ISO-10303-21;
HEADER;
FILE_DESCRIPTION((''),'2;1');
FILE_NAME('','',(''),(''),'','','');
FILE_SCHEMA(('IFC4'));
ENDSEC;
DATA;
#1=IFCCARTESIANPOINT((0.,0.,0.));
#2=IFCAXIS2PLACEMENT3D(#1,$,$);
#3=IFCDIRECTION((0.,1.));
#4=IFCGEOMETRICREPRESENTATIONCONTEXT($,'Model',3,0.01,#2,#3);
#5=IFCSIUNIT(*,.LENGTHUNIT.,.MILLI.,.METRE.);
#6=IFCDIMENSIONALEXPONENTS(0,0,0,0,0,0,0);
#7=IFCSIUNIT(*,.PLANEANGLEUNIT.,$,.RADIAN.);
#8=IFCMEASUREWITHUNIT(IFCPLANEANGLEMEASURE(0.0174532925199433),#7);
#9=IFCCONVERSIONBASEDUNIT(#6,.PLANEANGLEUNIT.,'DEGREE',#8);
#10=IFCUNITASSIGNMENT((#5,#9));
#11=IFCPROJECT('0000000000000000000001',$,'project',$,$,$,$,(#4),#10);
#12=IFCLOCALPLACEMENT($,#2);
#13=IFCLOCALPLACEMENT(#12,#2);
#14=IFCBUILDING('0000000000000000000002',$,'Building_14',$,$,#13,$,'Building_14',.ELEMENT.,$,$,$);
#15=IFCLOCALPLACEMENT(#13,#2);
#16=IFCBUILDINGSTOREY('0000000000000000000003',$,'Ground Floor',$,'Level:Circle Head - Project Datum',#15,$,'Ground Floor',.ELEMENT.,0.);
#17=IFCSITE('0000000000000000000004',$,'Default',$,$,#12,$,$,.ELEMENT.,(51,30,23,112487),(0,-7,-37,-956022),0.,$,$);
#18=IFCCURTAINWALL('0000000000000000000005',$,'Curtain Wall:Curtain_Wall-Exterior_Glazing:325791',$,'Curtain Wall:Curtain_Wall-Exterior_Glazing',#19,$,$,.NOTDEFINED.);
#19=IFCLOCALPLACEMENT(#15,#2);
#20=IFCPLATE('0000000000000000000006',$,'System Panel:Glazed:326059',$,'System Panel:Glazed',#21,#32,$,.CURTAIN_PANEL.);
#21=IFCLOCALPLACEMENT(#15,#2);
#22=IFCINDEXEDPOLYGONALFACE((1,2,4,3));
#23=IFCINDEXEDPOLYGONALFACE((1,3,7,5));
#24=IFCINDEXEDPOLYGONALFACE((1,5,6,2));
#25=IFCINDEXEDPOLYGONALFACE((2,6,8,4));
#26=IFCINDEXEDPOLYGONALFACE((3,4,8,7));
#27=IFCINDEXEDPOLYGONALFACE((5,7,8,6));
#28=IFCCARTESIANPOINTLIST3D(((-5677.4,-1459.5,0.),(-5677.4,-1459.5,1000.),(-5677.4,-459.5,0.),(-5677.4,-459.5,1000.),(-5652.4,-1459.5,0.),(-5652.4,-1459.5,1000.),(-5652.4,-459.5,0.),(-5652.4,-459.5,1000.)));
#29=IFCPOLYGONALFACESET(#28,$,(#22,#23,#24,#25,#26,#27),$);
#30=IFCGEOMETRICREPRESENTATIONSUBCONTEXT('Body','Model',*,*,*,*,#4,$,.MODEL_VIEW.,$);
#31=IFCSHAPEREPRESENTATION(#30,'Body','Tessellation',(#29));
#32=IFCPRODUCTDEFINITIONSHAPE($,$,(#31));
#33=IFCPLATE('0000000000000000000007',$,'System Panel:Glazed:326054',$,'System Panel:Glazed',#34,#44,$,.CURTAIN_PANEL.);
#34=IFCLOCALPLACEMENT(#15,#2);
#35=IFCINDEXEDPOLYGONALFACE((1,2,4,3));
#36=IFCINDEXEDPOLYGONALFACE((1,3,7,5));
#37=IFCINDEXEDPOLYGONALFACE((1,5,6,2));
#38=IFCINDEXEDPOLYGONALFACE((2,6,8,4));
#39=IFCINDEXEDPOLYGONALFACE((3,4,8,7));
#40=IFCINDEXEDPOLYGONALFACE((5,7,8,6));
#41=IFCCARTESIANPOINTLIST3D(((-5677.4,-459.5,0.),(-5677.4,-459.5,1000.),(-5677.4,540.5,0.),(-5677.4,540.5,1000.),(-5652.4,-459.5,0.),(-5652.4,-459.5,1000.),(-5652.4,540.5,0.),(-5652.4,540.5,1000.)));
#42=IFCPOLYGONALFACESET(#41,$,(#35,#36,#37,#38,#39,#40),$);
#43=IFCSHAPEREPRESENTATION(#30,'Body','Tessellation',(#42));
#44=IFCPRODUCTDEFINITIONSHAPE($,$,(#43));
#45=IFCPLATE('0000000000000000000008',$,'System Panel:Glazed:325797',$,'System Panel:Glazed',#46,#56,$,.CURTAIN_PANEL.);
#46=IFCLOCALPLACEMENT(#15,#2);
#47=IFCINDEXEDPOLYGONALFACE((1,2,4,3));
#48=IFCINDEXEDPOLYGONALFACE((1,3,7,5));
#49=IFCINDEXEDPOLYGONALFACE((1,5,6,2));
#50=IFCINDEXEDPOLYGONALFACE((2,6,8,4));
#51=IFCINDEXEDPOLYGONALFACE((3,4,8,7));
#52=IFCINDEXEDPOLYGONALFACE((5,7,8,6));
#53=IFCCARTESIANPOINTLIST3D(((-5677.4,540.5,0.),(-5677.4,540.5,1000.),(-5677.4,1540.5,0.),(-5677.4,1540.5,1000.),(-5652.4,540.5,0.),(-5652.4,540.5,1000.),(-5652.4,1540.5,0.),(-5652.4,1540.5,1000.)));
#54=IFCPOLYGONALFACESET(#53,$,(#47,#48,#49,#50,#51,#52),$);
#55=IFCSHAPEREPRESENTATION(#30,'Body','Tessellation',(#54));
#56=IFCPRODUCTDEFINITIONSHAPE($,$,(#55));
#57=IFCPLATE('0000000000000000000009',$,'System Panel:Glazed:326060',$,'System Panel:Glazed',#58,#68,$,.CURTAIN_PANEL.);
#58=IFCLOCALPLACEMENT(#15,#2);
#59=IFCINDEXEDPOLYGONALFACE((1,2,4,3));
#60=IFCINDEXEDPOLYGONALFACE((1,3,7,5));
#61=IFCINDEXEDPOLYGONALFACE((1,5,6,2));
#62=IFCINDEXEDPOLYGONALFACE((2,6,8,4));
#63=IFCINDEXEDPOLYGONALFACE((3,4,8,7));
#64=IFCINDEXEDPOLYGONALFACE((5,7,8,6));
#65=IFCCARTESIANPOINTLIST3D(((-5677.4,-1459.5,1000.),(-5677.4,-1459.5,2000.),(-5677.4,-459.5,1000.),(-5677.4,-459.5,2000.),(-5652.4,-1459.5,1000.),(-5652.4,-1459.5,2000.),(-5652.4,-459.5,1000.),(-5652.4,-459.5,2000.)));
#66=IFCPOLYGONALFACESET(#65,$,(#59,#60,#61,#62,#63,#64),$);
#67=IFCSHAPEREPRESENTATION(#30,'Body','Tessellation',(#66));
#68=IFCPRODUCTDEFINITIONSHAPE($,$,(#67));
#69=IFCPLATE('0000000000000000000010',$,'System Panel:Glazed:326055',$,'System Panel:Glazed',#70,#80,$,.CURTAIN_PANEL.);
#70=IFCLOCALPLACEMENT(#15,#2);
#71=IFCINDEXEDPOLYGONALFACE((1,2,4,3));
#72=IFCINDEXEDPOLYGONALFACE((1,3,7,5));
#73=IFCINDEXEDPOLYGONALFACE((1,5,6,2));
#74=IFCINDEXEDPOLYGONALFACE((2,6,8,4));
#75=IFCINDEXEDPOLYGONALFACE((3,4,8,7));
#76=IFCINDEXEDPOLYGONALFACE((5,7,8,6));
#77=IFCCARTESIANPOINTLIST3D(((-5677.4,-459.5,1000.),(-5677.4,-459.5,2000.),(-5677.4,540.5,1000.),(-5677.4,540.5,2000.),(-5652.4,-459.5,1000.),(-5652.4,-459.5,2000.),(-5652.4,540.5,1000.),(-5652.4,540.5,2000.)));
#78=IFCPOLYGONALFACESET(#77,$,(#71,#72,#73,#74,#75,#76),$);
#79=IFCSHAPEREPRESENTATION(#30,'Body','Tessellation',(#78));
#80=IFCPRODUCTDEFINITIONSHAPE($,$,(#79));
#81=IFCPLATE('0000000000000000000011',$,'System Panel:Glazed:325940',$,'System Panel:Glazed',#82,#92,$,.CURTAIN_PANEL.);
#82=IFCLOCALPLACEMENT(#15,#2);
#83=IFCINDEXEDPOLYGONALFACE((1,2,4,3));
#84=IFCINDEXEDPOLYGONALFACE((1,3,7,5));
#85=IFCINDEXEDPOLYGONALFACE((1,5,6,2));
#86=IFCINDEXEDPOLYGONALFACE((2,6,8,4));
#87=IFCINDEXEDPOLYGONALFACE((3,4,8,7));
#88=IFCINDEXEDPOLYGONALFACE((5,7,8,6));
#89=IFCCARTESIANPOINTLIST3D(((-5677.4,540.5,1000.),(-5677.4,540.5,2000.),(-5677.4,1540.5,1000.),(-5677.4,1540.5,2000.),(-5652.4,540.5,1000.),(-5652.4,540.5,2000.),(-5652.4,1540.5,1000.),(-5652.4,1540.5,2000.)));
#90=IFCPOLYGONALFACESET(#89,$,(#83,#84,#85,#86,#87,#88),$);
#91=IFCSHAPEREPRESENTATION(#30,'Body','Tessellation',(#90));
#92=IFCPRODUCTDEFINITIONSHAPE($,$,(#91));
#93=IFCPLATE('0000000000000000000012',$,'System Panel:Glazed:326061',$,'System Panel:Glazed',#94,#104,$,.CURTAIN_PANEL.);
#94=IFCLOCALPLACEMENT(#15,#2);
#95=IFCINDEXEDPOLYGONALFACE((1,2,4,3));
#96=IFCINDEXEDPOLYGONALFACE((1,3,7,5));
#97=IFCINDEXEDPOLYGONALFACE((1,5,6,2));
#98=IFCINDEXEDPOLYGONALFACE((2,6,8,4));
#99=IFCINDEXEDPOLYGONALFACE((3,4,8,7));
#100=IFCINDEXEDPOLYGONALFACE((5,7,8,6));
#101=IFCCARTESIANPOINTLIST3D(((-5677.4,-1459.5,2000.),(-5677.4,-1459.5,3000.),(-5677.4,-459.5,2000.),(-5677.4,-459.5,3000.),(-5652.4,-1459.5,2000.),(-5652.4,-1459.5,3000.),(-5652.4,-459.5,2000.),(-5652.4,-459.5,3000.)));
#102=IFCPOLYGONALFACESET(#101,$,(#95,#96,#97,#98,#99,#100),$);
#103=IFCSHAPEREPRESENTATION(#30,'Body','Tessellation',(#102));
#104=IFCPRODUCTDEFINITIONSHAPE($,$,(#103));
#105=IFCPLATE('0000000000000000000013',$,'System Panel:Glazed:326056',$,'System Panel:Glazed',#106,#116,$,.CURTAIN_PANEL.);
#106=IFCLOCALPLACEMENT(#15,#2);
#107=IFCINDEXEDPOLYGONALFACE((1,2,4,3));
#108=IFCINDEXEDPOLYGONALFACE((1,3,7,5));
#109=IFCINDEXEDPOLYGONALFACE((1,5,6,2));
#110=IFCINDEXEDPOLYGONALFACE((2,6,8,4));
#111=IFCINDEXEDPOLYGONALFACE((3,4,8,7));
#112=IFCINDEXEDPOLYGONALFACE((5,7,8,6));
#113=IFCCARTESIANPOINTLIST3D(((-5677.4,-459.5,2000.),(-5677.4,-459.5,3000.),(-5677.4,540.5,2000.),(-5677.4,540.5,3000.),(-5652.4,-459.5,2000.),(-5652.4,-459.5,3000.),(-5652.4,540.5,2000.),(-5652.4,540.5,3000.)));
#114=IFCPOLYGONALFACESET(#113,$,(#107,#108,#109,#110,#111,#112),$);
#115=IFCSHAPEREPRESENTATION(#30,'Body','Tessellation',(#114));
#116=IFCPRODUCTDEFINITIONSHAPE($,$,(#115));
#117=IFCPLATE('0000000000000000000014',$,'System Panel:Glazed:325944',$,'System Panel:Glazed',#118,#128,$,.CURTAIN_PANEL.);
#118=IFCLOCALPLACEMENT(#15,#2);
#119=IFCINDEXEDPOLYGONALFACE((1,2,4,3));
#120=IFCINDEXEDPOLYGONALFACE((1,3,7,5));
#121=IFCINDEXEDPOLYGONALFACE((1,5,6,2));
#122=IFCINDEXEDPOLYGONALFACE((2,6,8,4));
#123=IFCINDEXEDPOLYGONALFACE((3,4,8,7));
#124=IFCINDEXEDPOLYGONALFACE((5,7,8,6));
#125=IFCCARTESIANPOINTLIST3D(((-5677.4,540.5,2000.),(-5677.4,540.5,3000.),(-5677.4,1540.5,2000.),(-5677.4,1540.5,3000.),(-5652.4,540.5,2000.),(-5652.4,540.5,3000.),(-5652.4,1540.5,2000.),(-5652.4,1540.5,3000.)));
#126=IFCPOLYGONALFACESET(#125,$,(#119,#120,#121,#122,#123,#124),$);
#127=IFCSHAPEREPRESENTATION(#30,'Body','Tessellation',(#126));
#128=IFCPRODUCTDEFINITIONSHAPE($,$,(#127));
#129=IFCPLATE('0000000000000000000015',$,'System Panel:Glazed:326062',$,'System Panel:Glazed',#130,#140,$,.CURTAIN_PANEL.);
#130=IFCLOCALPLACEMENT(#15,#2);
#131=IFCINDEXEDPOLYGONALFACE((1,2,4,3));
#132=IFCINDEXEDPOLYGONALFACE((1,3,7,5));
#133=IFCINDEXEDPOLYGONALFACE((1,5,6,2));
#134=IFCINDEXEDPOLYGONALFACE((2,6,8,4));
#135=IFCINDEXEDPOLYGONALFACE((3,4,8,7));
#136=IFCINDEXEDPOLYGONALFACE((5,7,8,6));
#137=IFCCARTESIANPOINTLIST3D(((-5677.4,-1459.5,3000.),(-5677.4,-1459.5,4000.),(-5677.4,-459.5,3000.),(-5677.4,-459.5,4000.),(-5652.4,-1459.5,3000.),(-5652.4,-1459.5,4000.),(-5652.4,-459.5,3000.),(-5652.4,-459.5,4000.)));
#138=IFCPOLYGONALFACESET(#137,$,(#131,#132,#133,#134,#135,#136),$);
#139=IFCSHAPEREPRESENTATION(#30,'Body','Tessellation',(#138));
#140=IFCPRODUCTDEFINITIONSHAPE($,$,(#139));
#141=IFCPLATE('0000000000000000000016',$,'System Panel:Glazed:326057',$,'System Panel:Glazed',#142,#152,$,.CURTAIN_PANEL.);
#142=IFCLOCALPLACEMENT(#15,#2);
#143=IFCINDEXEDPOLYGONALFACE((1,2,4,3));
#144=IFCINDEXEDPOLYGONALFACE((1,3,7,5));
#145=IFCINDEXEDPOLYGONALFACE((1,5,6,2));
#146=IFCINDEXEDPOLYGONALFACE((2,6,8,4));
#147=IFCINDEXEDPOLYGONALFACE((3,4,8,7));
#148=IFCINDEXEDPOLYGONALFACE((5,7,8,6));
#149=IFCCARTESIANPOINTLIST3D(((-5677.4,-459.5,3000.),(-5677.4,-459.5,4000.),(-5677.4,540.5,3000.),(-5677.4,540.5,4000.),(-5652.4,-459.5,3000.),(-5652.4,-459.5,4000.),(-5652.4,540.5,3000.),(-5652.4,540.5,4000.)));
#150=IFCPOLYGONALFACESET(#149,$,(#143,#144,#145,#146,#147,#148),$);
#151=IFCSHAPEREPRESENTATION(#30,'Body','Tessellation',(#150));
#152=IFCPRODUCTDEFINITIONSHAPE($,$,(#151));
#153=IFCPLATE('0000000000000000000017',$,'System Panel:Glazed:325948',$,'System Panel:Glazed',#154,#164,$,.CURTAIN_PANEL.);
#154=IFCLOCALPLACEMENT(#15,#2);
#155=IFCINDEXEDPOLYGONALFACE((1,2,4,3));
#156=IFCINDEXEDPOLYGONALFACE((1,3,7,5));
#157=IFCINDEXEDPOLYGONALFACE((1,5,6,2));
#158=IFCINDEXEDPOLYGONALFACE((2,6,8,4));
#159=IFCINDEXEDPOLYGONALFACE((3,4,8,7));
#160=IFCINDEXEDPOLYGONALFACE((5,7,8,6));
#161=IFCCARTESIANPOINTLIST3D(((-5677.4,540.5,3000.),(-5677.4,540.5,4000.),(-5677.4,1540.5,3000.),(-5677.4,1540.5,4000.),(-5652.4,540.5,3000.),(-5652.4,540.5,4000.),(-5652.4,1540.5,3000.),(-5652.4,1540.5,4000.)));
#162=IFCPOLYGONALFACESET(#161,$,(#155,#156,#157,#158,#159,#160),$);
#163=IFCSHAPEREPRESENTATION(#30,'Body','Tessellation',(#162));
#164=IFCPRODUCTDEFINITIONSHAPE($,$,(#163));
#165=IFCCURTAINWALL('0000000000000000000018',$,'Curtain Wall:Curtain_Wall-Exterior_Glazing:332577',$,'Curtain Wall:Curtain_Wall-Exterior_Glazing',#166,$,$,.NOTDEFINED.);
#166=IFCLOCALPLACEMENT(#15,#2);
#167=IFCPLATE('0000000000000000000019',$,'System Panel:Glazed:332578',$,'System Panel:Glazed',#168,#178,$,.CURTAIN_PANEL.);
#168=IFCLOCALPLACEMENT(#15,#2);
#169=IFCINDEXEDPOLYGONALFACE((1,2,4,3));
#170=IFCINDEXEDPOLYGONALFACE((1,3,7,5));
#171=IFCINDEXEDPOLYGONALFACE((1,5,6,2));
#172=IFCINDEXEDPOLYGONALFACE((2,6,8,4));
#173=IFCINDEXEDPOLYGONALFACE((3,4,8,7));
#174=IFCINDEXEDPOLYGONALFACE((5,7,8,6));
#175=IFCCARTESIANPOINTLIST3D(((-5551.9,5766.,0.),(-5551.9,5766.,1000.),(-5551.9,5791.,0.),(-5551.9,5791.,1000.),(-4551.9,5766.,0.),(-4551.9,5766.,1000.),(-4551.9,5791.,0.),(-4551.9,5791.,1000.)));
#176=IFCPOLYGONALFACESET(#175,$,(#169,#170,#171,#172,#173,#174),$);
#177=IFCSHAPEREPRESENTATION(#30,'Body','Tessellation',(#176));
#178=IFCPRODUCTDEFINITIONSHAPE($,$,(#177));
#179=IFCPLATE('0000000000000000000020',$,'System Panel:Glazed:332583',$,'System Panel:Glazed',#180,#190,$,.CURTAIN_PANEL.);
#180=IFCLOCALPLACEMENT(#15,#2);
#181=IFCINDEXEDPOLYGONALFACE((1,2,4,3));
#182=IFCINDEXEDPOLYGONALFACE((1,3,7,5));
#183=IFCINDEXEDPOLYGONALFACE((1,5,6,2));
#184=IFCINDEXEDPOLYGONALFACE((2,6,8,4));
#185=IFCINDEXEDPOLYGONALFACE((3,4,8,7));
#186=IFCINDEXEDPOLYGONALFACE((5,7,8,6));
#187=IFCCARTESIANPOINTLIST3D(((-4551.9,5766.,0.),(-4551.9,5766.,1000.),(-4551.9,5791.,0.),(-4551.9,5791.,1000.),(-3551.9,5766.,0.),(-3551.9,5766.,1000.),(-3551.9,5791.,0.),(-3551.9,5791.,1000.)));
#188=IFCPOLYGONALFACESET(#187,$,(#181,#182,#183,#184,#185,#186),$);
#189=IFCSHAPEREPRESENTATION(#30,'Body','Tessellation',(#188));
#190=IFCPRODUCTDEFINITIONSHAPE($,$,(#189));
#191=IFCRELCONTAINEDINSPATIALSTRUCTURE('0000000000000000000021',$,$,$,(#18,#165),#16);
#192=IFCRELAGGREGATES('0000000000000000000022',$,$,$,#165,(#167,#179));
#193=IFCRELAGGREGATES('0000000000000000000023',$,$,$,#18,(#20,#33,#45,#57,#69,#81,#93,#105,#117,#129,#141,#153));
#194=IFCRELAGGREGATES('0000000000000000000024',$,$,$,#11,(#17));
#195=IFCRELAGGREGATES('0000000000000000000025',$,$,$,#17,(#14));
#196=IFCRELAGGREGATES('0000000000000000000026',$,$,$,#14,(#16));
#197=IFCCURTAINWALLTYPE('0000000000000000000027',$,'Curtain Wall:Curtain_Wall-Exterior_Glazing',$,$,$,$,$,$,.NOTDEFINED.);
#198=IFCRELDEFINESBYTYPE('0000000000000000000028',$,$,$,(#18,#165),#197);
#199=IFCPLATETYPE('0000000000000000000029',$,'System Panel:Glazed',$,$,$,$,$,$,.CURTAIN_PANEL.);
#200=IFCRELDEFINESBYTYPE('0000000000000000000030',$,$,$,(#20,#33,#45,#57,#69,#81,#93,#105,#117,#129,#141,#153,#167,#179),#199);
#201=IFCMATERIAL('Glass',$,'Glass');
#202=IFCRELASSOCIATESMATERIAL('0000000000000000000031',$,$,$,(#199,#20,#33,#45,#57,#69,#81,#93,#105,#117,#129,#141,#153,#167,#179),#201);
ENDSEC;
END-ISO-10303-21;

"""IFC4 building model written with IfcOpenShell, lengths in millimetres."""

from ifc_helpers import new_model, entity, si_unit, converted_unit, direction, frame, origin, place, context, subcontext, project, spatial, indexed_curve, outline, extrude, source, transform, mapped, material, type_object, type_shapes, element, aggregate, save


model = new_model("IFC4")

# Units and contexts
model_context = context("Model", 3, precision=0.01, world=origin(), true_north=direction((0.0, 1.0)))
body_context = subcontext(model_context, "Body", "Model", "MODEL_VIEW")
ifc_project = project(units=[si_unit("LENGTHUNIT", "METRE", prefix="MILLI"), converted_unit("PLANEANGLEUNIT", "DEGREE", entity("IfcPlaneAngleMeasure", 0.0174532925199433), si_unit("PLANEANGLEUNIT", "RADIAN"), dimensions=[0, 0, 0, 0, 0, 0, 0])], contexts=[model_context])

# Site, building, storey
site_placement = place(None, origin())
site = spatial("IfcSite", under=ifc_project, at=site_placement, Name="Default", CompositionType="ELEMENT", RefLatitude=(51, 30, 23, 112487), RefLongitude=(0, -7, -37, -956022), RefElevation=0.0)
building_placement = place(site_placement, origin())
building = spatial("IfcBuilding", under=site, at=building_placement, Name="Building_14", LongName="Building_14", CompositionType="ELEMENT")
storey_placement = place(building_placement, origin())
storey = spatial("IfcBuildingStorey", under=building, at=storey_placement, Name="Ground Floor", ObjectType="Level:Circle Head - Project Datum", LongName="Ground Floor", CompositionType="ELEMENT", Elevation=0.0)

# Curtain walls, plates
curtain_wall_type = type_object("IfcCurtainWallType", Name="Curtain Wall:Curtain_Wall-Exterior_Glazing", PredefinedType="NOTDEFINED")
curtain_wall_1_placement = place(storey_placement, origin())
curtain_wall_1 = element("IfcCurtainWall", 1, at=curtain_wall_1_placement, inside=storey, type_object=curtain_wall_type, Name="Curtain Wall:Curtain_Wall-Exterior_Glazing:325791", ObjectType="Curtain Wall:Curtain_Wall-Exterior_Glazing", PredefinedType="NOTDEFINED")
ifc_material = material(Name="Glass", Category="Glass")
plate_type_1 = type_object("IfcPlateType", Name="System Panel:Glazed", PredefinedType="CURTAIN_PANEL", material=ifc_material)
shared_shape_1 = source(origin(), body_context, "Body", "SweptSolid", [
    extrude(outline(indexed_curve([(-12.5, -500.0), (12.5, -500.0), (12.5, 500.0), (-12.5, 500.0), (-12.5, -500.0)], self_intersect=False)), frame((0.0, -37.0, 0.0), z_axis=(0.0, 0.0, 1.0), x_axis=(0.0, 1.0, 0.0)), (0.0, 0.0, 1.0), 1000.0),
])
type_shapes(plate_type_1, [shared_shape_1])
plate_1_placement = place(curtain_wall_1_placement, frame((-5701.9, -959.5, 0.0), z_axis=(0.0, 0.0, 1.0), x_axis=(0.0, 1.0, 0.0)))
plate_1 = element("IfcPlate", 2, at=plate_1_placement, type_object=plate_type_1, material=ifc_material, Name="System Panel:Glazed:326059", ObjectType="System Panel:Glazed", PredefinedType="CURTAIN_PANEL", context=body_context, shape_type="MappedRepresentation", body=[
    mapped(shared_shape_1, transform((0.0, 0.0, 0.0), scale=1.0)),
])
plate_2_placement = place(curtain_wall_1_placement, frame((-5701.9, 40.5, 0.0), z_axis=(0.0, 0.0, 1.0), x_axis=(0.0, 1.0, 0.0)))
plate_2 = element("IfcPlate", 3, at=plate_2_placement, type_object=plate_type_1, material=ifc_material, Name="System Panel:Glazed:326054", ObjectType="System Panel:Glazed", PredefinedType="CURTAIN_PANEL", context=body_context, shape_type="MappedRepresentation", body=[
    mapped(shared_shape_1, transform((0.0, 0.0, 0.0), scale=1.0)),
])
plate_3_placement = place(curtain_wall_1_placement, frame((-5701.9, 1040.5, 0.0), z_axis=(0.0, 0.0, 1.0), x_axis=(0.0, 1.0, 0.0)))
plate_3 = element("IfcPlate", 4, at=plate_3_placement, type_object=plate_type_1, material=ifc_material, Name="System Panel:Glazed:325797", ObjectType="System Panel:Glazed", PredefinedType="CURTAIN_PANEL", context=body_context, shape_type="MappedRepresentation", body=[
    mapped(shared_shape_1, transform((0.0, 0.0, 0.0), scale=1.0)),
])
plate_4_placement = place(curtain_wall_1_placement, frame((-5701.9, -959.5, 1000.0), z_axis=(0.0, 0.0, 1.0), x_axis=(0.0, 1.0, 0.0)))
plate_4 = element("IfcPlate", 5, at=plate_4_placement, type_object=plate_type_1, material=ifc_material, Name="System Panel:Glazed:326060", ObjectType="System Panel:Glazed", PredefinedType="CURTAIN_PANEL", context=body_context, shape_type="MappedRepresentation", body=[
    mapped(shared_shape_1, transform((0.0, 0.0, 0.0), scale=1.0)),
])
plate_5_placement = place(curtain_wall_1_placement, frame((-5701.9, 40.5, 1000.0), z_axis=(0.0, 0.0, 1.0), x_axis=(0.0, 1.0, 0.0)))
plate_5 = element("IfcPlate", 6, at=plate_5_placement, type_object=plate_type_1, material=ifc_material, Name="System Panel:Glazed:326055", ObjectType="System Panel:Glazed", PredefinedType="CURTAIN_PANEL", context=body_context, shape_type="MappedRepresentation", body=[
    mapped(shared_shape_1, transform((0.0, 0.0, 0.0), scale=1.0)),
])
plate_6_placement = place(curtain_wall_1_placement, frame((-5701.9, 1040.5, 1000.0), z_axis=(0.0, 0.0, 1.0), x_axis=(0.0, 1.0, 0.0)))
plate_6 = element("IfcPlate", 7, at=plate_6_placement, type_object=plate_type_1, material=ifc_material, Name="System Panel:Glazed:325940", ObjectType="System Panel:Glazed", PredefinedType="CURTAIN_PANEL", context=body_context, shape_type="MappedRepresentation", body=[
    mapped(shared_shape_1, transform((0.0, 0.0, 0.0), scale=1.0)),
])
plate_7_placement = place(curtain_wall_1_placement, frame((-5701.9, -959.5, 2000.0), z_axis=(0.0, 0.0, 1.0), x_axis=(0.0, 1.0, 0.0)))
plate_7 = element("IfcPlate", 8, at=plate_7_placement, type_object=plate_type_1, material=ifc_material, Name="System Panel:Glazed:326061", ObjectType="System Panel:Glazed", PredefinedType="CURTAIN_PANEL", context=body_context, shape_type="MappedRepresentation", body=[
    mapped(shared_shape_1, transform((0.0, 0.0, 0.0), scale=1.0)),
])
plate_8_placement = place(curtain_wall_1_placement, frame((-5701.9, 40.5, 2000.0), z_axis=(0.0, 0.0, 1.0), x_axis=(0.0, 1.0, 0.0)))
plate_8 = element("IfcPlate", 9, at=plate_8_placement, type_object=plate_type_1, material=ifc_material, Name="System Panel:Glazed:326056", ObjectType="System Panel:Glazed", PredefinedType="CURTAIN_PANEL", context=body_context, shape_type="MappedRepresentation", body=[
    mapped(shared_shape_1, transform((0.0, 0.0, 0.0), scale=1.0)),
])
plate_9_placement = place(curtain_wall_1_placement, frame((-5701.9, 1040.5, 2000.0), z_axis=(0.0, 0.0, 1.0), x_axis=(0.0, 1.0, 0.0)))
plate_9 = element("IfcPlate", 10, at=plate_9_placement, type_object=plate_type_1, material=ifc_material, Name="System Panel:Glazed:325944", ObjectType="System Panel:Glazed", PredefinedType="CURTAIN_PANEL", context=body_context, shape_type="MappedRepresentation", body=[
    mapped(shared_shape_1, transform((0.0, 0.0, 0.0), scale=1.0)),
])
plate_10_placement = place(curtain_wall_1_placement, frame((-5701.9, -959.5, 3000.0), z_axis=(0.0, 0.0, 1.0), x_axis=(0.0, 1.0, 0.0)))
plate_10 = element("IfcPlate", 11, at=plate_10_placement, type_object=plate_type_1, material=ifc_material, Name="System Panel:Glazed:326062", ObjectType="System Panel:Glazed", PredefinedType="CURTAIN_PANEL", context=body_context, shape_type="MappedRepresentation", body=[
    mapped(shared_shape_1, transform((0.0, 0.0, 0.0), scale=1.0)),
])
plate_11_placement = place(curtain_wall_1_placement, frame((-5701.9, 40.5, 3000.0), z_axis=(0.0, 0.0, 1.0), x_axis=(0.0, 1.0, 0.0)))
plate_11 = element("IfcPlate", 12, at=plate_11_placement, type_object=plate_type_1, material=ifc_material, Name="System Panel:Glazed:326057", ObjectType="System Panel:Glazed", PredefinedType="CURTAIN_PANEL", context=body_context, shape_type="MappedRepresentation", body=[
    mapped(shared_shape_1, transform((0.0, 0.0, 0.0), scale=1.0)),
])
plate_12_placement = place(curtain_wall_1_placement, frame((-5701.9, 1040.5, 3000.0), z_axis=(0.0, 0.0, 1.0), x_axis=(0.0, 1.0, 0.0)))
plate_12 = element("IfcPlate", 13, at=plate_12_placement, type_object=plate_type_1, material=ifc_material, Name="System Panel:Glazed:325948", ObjectType="System Panel:Glazed", PredefinedType="CURTAIN_PANEL", context=body_context, shape_type="MappedRepresentation", body=[
    mapped(shared_shape_1, transform((0.0, 0.0, 0.0), scale=1.0)),
])
curtain_wall_2_placement = place(storey_placement, origin())
curtain_wall_2 = element("IfcCurtainWall", 14, at=curtain_wall_2_placement, inside=storey, type_object=curtain_wall_type, Name="Curtain Wall:Curtain_Wall-Exterior_Glazing:332577", ObjectType="Curtain Wall:Curtain_Wall-Exterior_Glazing", PredefinedType="NOTDEFINED")
plate_13_placement = place(curtain_wall_2_placement, frame((-5051.9, 5815.5, 0.0)))
plate_13 = element("IfcPlate", 15, at=plate_13_placement, type_object=plate_type_1, material=ifc_material, Name="System Panel:Glazed:332578", ObjectType="System Panel:Glazed", PredefinedType="CURTAIN_PANEL", context=body_context, shape_type="MappedRepresentation", body=[
    mapped(shared_shape_1, transform((0.0, 0.0, 0.0), scale=1.0)),
])
plate_14_placement = place(curtain_wall_2_placement, frame((-4051.9, 5815.5, 0.0)))
plate_14 = element("IfcPlate", 16, at=plate_14_placement, type_object=plate_type_1, material=ifc_material, Name="System Panel:Glazed:332583", ObjectType="System Panel:Glazed", PredefinedType="CURTAIN_PANEL", context=body_context, shape_type="MappedRepresentation", body=[
    mapped(shared_shape_1, transform((0.0, 0.0, 0.0), scale=1.0)),
])
aggregate(curtain_wall_2, [plate_13, plate_14])

aggregate(curtain_wall_1, [plate_1, plate_2, plate_3, plate_4, plate_5, plate_6, plate_7, plate_8, plate_9, plate_10, plate_11, plate_12])

save(model, "model.ifc")
